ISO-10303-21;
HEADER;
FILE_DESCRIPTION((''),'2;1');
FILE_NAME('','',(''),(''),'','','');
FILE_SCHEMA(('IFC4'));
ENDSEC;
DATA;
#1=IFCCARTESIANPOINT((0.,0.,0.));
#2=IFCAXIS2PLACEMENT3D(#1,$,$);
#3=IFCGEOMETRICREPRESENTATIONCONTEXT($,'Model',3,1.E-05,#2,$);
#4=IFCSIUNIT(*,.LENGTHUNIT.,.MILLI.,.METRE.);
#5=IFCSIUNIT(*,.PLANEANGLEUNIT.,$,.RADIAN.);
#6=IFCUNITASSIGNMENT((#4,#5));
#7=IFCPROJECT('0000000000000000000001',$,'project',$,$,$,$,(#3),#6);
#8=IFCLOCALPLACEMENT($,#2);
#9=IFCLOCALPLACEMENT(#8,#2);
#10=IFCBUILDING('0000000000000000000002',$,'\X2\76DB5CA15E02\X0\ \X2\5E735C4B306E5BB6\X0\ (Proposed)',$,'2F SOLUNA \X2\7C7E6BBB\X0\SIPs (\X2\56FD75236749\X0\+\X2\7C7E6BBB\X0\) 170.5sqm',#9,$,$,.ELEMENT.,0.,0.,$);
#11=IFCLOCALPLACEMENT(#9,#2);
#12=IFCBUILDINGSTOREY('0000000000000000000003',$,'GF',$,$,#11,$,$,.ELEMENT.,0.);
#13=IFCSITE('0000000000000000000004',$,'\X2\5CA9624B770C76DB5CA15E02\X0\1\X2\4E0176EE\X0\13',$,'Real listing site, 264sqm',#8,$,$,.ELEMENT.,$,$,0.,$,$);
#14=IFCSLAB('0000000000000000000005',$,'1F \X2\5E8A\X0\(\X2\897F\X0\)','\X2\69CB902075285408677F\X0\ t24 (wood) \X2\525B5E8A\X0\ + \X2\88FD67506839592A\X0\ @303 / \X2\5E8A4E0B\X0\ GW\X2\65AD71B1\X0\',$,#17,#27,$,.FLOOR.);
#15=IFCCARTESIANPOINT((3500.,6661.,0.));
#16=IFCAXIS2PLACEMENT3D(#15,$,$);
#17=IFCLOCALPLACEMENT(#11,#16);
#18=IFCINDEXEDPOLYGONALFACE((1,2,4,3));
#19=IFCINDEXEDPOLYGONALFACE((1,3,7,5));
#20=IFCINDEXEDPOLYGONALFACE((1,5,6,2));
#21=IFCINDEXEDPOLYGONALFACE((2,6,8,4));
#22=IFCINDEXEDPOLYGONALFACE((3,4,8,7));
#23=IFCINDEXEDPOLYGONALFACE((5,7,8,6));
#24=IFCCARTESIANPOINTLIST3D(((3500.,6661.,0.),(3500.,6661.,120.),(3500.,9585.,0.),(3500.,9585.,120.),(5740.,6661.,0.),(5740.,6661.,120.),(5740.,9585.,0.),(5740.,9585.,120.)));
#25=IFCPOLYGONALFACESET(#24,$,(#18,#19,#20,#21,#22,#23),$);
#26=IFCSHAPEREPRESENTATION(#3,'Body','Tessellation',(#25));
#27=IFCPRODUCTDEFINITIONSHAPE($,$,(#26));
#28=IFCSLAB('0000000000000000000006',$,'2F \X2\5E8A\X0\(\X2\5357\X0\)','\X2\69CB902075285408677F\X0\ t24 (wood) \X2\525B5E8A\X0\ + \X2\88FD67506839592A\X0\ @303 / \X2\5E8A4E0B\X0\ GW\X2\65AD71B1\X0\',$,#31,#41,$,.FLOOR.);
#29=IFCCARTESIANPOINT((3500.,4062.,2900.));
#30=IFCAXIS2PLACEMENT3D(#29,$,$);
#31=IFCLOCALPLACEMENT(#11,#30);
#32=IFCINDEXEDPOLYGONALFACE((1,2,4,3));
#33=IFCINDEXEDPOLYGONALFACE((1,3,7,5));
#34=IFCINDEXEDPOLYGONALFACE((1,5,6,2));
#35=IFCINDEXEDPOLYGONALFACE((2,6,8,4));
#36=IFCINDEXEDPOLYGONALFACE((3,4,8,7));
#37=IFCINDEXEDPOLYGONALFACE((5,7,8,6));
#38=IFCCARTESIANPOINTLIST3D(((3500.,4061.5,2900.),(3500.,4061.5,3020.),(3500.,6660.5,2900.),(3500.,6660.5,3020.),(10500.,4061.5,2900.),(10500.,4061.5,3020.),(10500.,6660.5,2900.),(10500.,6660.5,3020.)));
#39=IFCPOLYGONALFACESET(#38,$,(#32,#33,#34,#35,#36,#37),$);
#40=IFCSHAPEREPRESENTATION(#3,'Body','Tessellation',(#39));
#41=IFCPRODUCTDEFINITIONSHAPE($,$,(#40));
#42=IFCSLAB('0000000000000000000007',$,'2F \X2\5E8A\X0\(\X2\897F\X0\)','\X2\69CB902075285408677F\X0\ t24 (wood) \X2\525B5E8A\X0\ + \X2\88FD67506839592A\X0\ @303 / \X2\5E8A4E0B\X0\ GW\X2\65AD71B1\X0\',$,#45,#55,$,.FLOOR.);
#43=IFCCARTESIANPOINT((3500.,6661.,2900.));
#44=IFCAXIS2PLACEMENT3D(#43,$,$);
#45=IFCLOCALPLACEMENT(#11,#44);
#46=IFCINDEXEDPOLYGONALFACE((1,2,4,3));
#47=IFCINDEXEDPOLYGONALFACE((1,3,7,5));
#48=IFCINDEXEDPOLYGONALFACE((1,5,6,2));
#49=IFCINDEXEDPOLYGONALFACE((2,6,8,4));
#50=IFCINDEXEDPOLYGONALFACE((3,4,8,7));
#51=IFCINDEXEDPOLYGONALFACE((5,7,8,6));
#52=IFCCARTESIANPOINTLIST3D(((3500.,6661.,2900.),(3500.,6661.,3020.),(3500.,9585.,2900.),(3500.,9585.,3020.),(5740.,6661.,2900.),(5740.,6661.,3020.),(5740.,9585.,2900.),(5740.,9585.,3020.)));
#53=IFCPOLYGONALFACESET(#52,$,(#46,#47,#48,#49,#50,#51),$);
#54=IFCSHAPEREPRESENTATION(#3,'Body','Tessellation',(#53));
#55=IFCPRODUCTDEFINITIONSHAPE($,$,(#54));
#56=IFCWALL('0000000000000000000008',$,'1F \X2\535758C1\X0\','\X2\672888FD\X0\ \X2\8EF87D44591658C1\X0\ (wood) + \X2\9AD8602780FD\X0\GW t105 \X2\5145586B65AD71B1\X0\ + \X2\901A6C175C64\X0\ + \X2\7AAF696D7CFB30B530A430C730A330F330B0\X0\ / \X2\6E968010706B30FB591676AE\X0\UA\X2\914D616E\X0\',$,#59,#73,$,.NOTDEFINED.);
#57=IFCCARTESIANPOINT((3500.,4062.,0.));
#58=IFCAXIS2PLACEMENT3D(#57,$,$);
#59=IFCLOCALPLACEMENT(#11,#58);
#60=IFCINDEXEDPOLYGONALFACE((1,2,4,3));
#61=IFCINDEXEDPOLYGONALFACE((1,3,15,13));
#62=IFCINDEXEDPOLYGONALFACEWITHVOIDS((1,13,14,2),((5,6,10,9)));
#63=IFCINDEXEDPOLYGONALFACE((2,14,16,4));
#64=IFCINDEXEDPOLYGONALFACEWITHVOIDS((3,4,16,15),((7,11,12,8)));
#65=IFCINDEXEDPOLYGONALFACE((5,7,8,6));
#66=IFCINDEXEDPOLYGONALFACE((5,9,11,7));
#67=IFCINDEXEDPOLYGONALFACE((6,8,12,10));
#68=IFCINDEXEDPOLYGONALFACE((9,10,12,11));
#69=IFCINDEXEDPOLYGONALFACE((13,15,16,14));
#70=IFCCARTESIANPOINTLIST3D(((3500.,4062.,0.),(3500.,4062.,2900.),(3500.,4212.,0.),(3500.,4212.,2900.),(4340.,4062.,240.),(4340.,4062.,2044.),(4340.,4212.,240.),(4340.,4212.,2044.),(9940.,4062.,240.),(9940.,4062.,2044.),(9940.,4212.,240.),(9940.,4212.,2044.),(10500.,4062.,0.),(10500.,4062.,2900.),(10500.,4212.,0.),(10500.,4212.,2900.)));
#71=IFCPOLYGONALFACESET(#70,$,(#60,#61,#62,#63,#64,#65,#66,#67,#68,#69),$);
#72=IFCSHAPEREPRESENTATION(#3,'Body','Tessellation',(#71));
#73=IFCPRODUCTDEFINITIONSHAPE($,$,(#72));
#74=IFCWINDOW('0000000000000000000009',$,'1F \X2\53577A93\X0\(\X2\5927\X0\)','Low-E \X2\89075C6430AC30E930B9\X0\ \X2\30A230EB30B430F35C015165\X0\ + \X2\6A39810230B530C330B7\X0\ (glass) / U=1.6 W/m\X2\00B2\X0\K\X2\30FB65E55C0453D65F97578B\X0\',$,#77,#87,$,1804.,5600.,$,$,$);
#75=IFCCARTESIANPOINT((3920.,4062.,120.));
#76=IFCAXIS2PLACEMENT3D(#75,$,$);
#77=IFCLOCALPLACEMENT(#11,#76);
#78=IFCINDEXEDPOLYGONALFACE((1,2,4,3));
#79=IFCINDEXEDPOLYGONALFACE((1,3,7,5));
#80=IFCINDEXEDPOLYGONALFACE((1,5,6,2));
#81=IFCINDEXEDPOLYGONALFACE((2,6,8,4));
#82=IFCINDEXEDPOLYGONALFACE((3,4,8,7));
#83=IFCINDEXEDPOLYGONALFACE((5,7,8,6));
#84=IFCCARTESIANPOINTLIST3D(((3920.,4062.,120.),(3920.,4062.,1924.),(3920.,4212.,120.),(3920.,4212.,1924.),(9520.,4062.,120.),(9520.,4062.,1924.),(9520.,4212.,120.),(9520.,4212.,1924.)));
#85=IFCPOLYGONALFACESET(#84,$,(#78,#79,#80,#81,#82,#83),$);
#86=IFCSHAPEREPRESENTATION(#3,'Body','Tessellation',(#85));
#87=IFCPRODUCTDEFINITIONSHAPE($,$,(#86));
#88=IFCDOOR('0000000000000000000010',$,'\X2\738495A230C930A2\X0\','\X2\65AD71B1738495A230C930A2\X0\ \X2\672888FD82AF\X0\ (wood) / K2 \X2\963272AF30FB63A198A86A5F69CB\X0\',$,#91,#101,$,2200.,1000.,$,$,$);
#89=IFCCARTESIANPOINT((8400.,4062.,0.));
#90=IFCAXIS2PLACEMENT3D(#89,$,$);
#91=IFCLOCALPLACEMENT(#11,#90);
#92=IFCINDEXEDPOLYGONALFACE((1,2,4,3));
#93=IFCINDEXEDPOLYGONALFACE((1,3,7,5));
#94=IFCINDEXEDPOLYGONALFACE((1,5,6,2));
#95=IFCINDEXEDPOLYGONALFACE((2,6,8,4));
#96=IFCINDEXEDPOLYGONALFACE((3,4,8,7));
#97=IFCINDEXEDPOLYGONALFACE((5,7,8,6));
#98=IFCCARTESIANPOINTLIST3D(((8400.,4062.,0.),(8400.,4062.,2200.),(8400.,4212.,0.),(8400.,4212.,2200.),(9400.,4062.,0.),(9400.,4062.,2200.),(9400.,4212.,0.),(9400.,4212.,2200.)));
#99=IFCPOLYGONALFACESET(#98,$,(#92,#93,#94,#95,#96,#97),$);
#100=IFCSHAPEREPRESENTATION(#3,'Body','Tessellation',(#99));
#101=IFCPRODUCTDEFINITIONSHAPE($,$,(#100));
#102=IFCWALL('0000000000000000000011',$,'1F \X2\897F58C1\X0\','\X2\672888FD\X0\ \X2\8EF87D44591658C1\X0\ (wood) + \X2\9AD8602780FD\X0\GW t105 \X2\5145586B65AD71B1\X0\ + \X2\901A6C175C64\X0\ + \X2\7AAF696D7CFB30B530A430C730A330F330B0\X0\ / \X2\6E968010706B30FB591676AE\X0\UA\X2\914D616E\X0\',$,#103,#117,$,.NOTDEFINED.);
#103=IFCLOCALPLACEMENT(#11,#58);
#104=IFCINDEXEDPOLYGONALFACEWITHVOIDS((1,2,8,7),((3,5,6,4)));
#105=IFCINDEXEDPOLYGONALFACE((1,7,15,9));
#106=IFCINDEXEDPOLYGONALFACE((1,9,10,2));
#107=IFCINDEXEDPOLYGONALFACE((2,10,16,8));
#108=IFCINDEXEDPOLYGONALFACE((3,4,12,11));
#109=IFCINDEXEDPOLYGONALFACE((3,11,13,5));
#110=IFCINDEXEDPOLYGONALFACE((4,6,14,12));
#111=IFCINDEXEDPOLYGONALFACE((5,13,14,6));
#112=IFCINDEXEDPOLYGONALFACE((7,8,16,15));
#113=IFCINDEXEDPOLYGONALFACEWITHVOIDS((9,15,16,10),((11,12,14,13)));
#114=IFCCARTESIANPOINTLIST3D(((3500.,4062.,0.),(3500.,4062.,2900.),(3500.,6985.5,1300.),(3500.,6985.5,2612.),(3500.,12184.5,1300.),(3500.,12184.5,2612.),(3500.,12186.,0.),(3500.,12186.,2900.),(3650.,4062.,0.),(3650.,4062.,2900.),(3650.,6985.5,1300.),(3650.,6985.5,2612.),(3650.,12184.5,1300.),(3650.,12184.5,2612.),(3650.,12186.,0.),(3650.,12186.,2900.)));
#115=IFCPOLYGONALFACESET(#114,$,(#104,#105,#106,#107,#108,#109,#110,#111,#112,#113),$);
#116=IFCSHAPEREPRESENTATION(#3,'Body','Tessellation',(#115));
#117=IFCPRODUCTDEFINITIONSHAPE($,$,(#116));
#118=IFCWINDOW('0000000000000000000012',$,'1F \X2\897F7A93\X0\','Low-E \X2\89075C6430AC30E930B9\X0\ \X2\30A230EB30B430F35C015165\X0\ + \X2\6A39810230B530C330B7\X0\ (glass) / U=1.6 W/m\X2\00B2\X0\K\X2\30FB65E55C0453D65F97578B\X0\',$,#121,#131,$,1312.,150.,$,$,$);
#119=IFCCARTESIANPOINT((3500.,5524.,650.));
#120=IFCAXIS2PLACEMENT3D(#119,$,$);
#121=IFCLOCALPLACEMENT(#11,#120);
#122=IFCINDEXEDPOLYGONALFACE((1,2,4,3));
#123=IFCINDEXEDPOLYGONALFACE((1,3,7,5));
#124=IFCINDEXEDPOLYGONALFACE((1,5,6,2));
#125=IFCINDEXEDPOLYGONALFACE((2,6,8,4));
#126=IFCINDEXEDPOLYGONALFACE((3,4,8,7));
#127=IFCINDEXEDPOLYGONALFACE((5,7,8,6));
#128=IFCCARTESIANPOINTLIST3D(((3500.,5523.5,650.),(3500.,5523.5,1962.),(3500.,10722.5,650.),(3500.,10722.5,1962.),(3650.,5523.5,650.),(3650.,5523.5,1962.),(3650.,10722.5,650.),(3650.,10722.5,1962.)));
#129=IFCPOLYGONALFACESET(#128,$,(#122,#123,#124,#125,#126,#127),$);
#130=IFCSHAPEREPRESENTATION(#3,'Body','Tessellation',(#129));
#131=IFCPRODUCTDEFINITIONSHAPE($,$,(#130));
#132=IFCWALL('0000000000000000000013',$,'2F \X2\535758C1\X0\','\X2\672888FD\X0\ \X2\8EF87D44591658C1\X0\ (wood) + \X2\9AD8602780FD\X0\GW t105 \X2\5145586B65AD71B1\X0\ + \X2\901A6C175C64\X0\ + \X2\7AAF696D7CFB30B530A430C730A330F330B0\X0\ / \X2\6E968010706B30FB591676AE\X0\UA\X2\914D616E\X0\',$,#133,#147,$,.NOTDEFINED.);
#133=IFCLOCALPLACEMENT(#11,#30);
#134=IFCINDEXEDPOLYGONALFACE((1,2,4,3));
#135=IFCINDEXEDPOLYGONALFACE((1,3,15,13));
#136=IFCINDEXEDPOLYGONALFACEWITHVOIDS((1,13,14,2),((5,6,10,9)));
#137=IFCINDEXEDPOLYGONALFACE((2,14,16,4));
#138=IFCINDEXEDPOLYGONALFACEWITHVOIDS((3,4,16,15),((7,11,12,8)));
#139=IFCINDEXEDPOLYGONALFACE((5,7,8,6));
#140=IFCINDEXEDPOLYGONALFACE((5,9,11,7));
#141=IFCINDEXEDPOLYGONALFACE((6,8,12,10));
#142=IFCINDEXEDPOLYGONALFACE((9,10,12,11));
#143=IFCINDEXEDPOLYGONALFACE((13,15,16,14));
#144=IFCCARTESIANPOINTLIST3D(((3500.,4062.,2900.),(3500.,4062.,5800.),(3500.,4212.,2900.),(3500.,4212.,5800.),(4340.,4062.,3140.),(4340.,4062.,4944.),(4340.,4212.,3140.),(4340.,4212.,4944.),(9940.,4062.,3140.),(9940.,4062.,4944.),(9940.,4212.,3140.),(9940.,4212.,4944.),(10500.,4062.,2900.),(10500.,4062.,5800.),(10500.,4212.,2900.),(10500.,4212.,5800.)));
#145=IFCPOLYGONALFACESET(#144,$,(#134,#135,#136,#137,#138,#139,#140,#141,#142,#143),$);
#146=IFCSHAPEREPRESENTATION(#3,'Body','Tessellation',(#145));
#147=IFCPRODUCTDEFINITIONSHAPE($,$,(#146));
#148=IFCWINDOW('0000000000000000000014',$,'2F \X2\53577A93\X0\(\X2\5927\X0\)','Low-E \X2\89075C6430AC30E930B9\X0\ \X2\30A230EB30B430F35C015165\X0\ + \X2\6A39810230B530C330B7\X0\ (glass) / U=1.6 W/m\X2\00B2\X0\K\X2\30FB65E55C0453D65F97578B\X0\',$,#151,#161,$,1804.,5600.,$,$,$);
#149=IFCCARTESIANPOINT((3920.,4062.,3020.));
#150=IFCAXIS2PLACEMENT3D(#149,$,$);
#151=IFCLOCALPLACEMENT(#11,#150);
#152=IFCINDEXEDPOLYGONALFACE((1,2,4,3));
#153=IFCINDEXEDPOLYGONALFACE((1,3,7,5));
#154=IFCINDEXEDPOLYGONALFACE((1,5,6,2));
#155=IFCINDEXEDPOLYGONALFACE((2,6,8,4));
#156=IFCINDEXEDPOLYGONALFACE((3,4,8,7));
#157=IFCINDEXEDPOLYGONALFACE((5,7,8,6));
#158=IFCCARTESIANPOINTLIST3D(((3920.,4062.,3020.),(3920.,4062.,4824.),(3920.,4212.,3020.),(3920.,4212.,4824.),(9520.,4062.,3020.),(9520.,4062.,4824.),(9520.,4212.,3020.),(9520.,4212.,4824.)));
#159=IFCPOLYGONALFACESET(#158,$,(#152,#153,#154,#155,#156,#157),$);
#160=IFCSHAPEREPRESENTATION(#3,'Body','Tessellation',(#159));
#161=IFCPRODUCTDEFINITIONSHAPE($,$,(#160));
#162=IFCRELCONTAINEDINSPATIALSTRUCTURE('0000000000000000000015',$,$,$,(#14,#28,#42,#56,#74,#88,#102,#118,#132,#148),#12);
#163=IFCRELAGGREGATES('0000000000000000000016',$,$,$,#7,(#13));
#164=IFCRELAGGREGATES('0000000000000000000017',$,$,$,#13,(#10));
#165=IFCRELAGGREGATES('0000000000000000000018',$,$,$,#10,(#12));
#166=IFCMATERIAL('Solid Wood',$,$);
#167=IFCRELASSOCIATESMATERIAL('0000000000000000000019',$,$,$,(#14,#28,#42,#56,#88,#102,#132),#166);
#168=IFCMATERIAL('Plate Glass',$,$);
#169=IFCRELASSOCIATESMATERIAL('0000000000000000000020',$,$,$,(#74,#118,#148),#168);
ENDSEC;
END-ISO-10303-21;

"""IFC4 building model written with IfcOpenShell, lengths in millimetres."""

from ifc_helpers import new_model, si_unit, frame, frame_2d, origin, place, context, project, spatial, rectangle, extrude, material, element, fill, save


model = new_model("IFC4")

# Units and contexts
model_context = context("Model", 3, precision=1e-05, world=origin())
ifc_project = project(units=[si_unit("LENGTHUNIT", "METRE", prefix="MILLI"), si_unit("PLANEANGLEUNIT", "RADIAN")], contexts=[model_context])

# Site, building, storey
site_placement = place(None, origin())
site = spatial("IfcSite", under=ifc_project, at=site_placement, Name="岩手県盛岡市1丁目13", ObjectType="Real listing site, 264sqm", CompositionType="ELEMENT", RefElevation=0.0)
building_placement = place(site_placement, origin())
building = spatial("IfcBuilding", under=site, at=building_placement, Name="盛岡市 平屋の家 (Proposed)", ObjectType="2F SOLUNA 籾殻SIPs (国産杉+籾殻) 170.5sqm", CompositionType="ELEMENT", ElevationOfRefHeight=0.0, ElevationOfTerrain=0.0)
storey_placement = place(building_placement, origin())
storey = spatial("IfcBuildingStorey", under=building, at=storey_placement, Name="GF", CompositionType="ELEMENT", Elevation=0.0)

# Slabs
ifc_material_1 = material(Name="Solid Wood")
slab_1_placement = place(storey_placement, frame((3500.0, 6661.0, 0.0)))
element("IfcSlab", 1, at=slab_1_placement, inside=storey, material=ifc_material_1, Name="1F 床(西)", Description="構造用合板 t24 (wood) 剛床 + 製材根太 @303 / 床下 GW断熱", PredefinedType="FLOOR", context=model_context, shape_type="SweptSolid", body=[
    extrude(rectangle(XDim=2240.0, YDim=2924.0, at=frame_2d((1120.0, 1462.0))), frame((3500.0, 6661.0, 0.0)), (0.0, 0.0, 1.0), 120.0),
])
slab_2_placement = place(storey_placement, frame((3500.0, 4062.0, 2900.0)))
element("IfcSlab", 2, at=slab_2_placement, inside=storey, material=ifc_material_1, Name="2F 床(南)", Description="構造用合板 t24 (wood) 剛床 + 製材根太 @303 / 床下 GW断熱", PredefinedType="FLOOR", context=model_context, shape_type="SweptSolid", body=[
    extrude(rectangle(XDim=7000.0, YDim=2599.0, at=frame_2d((3500.0, 1299.0))), frame((3500.0, 4062.0, 2900.0)), (0.0, 0.0, 1.0), 120.0),
])
slab_3_placement = place(storey_placement, frame((3500.0, 6661.0, 2900.0)))
element("IfcSlab", 3, at=slab_3_placement, inside=storey, material=ifc_material_1, Name="2F 床(西)", Description="構造用合板 t24 (wood) 剛床 + 製材根太 @303 / 床下 GW断熱", PredefinedType="FLOOR", context=model_context, shape_type="SweptSolid", body=[
    extrude(rectangle(XDim=2240.0, YDim=2924.0, at=frame_2d((1120.0, 1462.0))), frame((3500.0, 6661.0, 2900.0)), (0.0, 0.0, 1.0), 120.0),
])

# Wall, openings, window, door
wall_1_placement = place(storey_placement, frame((3500.0, 4062.0, 0.0)))
wall_1 = element("IfcWall", 4, at=wall_1_placement, inside=storey, material=ifc_material_1, Name="1F 南壁", Description="木製 軸組外壁 (wood) + 高性能GW t105 充填断熱 + 通気層 + 窯業系サイディング / 準耐火・外皮UA配慮", PredefinedType="NOTDEFINED", context=model_context, shape_type="SweptSolid", body=[
    extrude(rectangle(XDim=7000.0, YDim=150.0, at=frame_2d((3500.0, 75.0))), frame((3500.0, 4062.0, 0.0)), (0.0, 0.0, 1.0), 2900.0),
])
opening_1_placement = place(storey_placement, frame((3920.0, 4062.0, 120.0)))
opening_1 = element("IfcOpeningElement", 5, at=opening_1_placement, cuts=wall_1, PredefinedType="NOTDEFINED", context=model_context, shape_type="SweptSolid", body=[
    extrude(rectangle(XDim=5600.0, YDim=150.0, at=frame_2d((2800.0, 75.0))), frame((3920.0, 4062.0, 120.0)), (0.0, 0.0, 1.0), 1804.0),
])
opening_2_placement = place(storey_placement, frame((8400.0, 4062.0, 0.0)))
opening_2 = element("IfcOpeningElement", 6, at=opening_2_placement, cuts=wall_1, PredefinedType="NOTDEFINED", context=model_context, shape_type="SweptSolid", body=[
    extrude(rectangle(XDim=1000.0, YDim=150.0, at=frame_2d((500.0, 75.0))), frame((8400.0, 4062.0, 0.0)), (0.0, 0.0, 1.0), 2200.0),
])
ifc_material_2 = material(Name="Plate Glass")
window_1_placement = place(storey_placement, frame((3920.0, 4062.0, 120.0)))
window_1 = element("IfcWindow", 7, at=window_1_placement, inside=storey, material=ifc_material_2, Name="1F 南窓(大)", Description="Low-E 複層ガラス アルゴン封入 + 樹脂サッシ (glass) / U=1.6 W/m²K・日射取得型", OverallHeight=1804.0, OverallWidth=5600.0, context=model_context, shape_type="SweptSolid", body=[
    extrude(rectangle(XDim=5600.0, YDim=150.0, at=frame_2d((2800.0, 75.0))), frame((3920.0, 4062.0, 120.0)), (0.0, 0.0, 1.0), 1804.0),
])
fill(opening_1, window_1)
door_placement = place(storey_placement, frame((8400.0, 4062.0, 0.0)))
door = element("IfcDoor", 8, at=door_placement, inside=storey, material=ifc_material_1, Name="玄関ドア", Description="断熱玄関ドア 木製芯 (wood) / K2 防犯・採風機構", OverallHeight=2200.0, OverallWidth=1000.0, context=model_context, shape_type="SweptSolid", body=[
    extrude(rectangle(XDim=1000.0, YDim=150.0, at=frame_2d((500.0, 75.0))), frame((8400.0, 4062.0, 0.0)), (0.0, 0.0, 1.0), 2200.0),
])
fill(opening_2, door)

# Walls, openings, windows
wall_2_placement = place(storey_placement, frame((3500.0, 4062.0, 0.0)))
wall_2 = element("IfcWall", 9, at=wall_2_placement, inside=storey, material=ifc_material_1, Name="1F 西壁", Description="木製 軸組外壁 (wood) + 高性能GW t105 充填断熱 + 通気層 + 窯業系サイディング / 準耐火・外皮UA配慮", PredefinedType="NOTDEFINED", context=model_context, shape_type="SweptSolid", body=[
    extrude(rectangle(XDim=150.0, YDim=8124.0, at=frame_2d((75.0, 4062.0))), frame((3500.0, 4062.0, 0.0)), (0.0, 0.0, 1.0), 2900.0),
])
opening_3_placement = place(storey_placement, frame((3500.0, 5524.0, 650.0)))
opening_3 = element("IfcOpeningElement", 10, at=opening_3_placement, cuts=wall_2, PredefinedType="NOTDEFINED", context=model_context, shape_type="SweptSolid", body=[
    extrude(rectangle(XDim=150.0, YDim=5199.0, at=frame_2d((75.0, 2599.0))), frame((3500.0, 5524.0, 650.0)), (0.0, 0.0, 1.0), 1312.0),
])
window_2_placement = place(storey_placement, frame((3500.0, 5524.0, 650.0)))
window_2 = element("IfcWindow", 11, at=window_2_placement, inside=storey, material=ifc_material_2, Name="1F 西窓", Description="Low-E 複層ガラス アルゴン封入 + 樹脂サッシ (glass) / U=1.6 W/m²K・日射取得型", OverallHeight=1312.0, OverallWidth=150.0, context=model_context, shape_type="SweptSolid", body=[
    extrude(rectangle(XDim=150.0, YDim=5199.0, at=frame_2d((75.0, 2599.0))), frame((3500.0, 5524.0, 650.0)), (0.0, 0.0, 1.0), 1312.0),
])
fill(opening_3, window_2)
wall_3_placement = place(storey_placement, frame((3500.0, 4062.0, 2900.0)))
wall_3 = element("IfcWall", 12, at=wall_3_placement, inside=storey, material=ifc_material_1, Name="2F 南壁", Description="木製 軸組外壁 (wood) + 高性能GW t105 充填断熱 + 通気層 + 窯業系サイディング / 準耐火・外皮UA配慮", PredefinedType="NOTDEFINED", context=model_context, shape_type="SweptSolid", body=[
    extrude(rectangle(XDim=7000.0, YDim=150.0, at=frame_2d((3500.0, 75.0))), frame((3500.0, 4062.0, 2900.0)), (0.0, 0.0, 1.0), 2900.0),
])
opening_4_placement = place(storey_placement, frame((3920.0, 4062.0, 3020.0)))
opening_4 = element("IfcOpeningElement", 13, at=opening_4_placement, cuts=wall_3, PredefinedType="NOTDEFINED", context=model_context, shape_type="SweptSolid", body=[
    extrude(rectangle(XDim=5600.0, YDim=150.0, at=frame_2d((2800.0, 75.0))), frame((3920.0, 4062.0, 3020.0)), (0.0, 0.0, 1.0), 1804.0),
])
window_3_placement = place(storey_placement, frame((3920.0, 4062.0, 3020.0)))
window_3 = element("IfcWindow", 14, at=window_3_placement, inside=storey, material=ifc_material_2, Name="2F 南窓(大)", Description="Low-E 複層ガラス アルゴン封入 + 樹脂サッシ (glass) / U=1.6 W/m²K・日射取得型", OverallHeight=1804.0, OverallWidth=5600.0, context=model_context, shape_type="SweptSolid", body=[
    extrude(rectangle(XDim=5600.0, YDim=150.0, at=frame_2d((2800.0, 75.0))), frame((3920.0, 4062.0, 3020.0)), (0.0, 0.0, 1.0), 1804.0),
])
fill(opening_4, window_3)

save(model, "model.ifc")
